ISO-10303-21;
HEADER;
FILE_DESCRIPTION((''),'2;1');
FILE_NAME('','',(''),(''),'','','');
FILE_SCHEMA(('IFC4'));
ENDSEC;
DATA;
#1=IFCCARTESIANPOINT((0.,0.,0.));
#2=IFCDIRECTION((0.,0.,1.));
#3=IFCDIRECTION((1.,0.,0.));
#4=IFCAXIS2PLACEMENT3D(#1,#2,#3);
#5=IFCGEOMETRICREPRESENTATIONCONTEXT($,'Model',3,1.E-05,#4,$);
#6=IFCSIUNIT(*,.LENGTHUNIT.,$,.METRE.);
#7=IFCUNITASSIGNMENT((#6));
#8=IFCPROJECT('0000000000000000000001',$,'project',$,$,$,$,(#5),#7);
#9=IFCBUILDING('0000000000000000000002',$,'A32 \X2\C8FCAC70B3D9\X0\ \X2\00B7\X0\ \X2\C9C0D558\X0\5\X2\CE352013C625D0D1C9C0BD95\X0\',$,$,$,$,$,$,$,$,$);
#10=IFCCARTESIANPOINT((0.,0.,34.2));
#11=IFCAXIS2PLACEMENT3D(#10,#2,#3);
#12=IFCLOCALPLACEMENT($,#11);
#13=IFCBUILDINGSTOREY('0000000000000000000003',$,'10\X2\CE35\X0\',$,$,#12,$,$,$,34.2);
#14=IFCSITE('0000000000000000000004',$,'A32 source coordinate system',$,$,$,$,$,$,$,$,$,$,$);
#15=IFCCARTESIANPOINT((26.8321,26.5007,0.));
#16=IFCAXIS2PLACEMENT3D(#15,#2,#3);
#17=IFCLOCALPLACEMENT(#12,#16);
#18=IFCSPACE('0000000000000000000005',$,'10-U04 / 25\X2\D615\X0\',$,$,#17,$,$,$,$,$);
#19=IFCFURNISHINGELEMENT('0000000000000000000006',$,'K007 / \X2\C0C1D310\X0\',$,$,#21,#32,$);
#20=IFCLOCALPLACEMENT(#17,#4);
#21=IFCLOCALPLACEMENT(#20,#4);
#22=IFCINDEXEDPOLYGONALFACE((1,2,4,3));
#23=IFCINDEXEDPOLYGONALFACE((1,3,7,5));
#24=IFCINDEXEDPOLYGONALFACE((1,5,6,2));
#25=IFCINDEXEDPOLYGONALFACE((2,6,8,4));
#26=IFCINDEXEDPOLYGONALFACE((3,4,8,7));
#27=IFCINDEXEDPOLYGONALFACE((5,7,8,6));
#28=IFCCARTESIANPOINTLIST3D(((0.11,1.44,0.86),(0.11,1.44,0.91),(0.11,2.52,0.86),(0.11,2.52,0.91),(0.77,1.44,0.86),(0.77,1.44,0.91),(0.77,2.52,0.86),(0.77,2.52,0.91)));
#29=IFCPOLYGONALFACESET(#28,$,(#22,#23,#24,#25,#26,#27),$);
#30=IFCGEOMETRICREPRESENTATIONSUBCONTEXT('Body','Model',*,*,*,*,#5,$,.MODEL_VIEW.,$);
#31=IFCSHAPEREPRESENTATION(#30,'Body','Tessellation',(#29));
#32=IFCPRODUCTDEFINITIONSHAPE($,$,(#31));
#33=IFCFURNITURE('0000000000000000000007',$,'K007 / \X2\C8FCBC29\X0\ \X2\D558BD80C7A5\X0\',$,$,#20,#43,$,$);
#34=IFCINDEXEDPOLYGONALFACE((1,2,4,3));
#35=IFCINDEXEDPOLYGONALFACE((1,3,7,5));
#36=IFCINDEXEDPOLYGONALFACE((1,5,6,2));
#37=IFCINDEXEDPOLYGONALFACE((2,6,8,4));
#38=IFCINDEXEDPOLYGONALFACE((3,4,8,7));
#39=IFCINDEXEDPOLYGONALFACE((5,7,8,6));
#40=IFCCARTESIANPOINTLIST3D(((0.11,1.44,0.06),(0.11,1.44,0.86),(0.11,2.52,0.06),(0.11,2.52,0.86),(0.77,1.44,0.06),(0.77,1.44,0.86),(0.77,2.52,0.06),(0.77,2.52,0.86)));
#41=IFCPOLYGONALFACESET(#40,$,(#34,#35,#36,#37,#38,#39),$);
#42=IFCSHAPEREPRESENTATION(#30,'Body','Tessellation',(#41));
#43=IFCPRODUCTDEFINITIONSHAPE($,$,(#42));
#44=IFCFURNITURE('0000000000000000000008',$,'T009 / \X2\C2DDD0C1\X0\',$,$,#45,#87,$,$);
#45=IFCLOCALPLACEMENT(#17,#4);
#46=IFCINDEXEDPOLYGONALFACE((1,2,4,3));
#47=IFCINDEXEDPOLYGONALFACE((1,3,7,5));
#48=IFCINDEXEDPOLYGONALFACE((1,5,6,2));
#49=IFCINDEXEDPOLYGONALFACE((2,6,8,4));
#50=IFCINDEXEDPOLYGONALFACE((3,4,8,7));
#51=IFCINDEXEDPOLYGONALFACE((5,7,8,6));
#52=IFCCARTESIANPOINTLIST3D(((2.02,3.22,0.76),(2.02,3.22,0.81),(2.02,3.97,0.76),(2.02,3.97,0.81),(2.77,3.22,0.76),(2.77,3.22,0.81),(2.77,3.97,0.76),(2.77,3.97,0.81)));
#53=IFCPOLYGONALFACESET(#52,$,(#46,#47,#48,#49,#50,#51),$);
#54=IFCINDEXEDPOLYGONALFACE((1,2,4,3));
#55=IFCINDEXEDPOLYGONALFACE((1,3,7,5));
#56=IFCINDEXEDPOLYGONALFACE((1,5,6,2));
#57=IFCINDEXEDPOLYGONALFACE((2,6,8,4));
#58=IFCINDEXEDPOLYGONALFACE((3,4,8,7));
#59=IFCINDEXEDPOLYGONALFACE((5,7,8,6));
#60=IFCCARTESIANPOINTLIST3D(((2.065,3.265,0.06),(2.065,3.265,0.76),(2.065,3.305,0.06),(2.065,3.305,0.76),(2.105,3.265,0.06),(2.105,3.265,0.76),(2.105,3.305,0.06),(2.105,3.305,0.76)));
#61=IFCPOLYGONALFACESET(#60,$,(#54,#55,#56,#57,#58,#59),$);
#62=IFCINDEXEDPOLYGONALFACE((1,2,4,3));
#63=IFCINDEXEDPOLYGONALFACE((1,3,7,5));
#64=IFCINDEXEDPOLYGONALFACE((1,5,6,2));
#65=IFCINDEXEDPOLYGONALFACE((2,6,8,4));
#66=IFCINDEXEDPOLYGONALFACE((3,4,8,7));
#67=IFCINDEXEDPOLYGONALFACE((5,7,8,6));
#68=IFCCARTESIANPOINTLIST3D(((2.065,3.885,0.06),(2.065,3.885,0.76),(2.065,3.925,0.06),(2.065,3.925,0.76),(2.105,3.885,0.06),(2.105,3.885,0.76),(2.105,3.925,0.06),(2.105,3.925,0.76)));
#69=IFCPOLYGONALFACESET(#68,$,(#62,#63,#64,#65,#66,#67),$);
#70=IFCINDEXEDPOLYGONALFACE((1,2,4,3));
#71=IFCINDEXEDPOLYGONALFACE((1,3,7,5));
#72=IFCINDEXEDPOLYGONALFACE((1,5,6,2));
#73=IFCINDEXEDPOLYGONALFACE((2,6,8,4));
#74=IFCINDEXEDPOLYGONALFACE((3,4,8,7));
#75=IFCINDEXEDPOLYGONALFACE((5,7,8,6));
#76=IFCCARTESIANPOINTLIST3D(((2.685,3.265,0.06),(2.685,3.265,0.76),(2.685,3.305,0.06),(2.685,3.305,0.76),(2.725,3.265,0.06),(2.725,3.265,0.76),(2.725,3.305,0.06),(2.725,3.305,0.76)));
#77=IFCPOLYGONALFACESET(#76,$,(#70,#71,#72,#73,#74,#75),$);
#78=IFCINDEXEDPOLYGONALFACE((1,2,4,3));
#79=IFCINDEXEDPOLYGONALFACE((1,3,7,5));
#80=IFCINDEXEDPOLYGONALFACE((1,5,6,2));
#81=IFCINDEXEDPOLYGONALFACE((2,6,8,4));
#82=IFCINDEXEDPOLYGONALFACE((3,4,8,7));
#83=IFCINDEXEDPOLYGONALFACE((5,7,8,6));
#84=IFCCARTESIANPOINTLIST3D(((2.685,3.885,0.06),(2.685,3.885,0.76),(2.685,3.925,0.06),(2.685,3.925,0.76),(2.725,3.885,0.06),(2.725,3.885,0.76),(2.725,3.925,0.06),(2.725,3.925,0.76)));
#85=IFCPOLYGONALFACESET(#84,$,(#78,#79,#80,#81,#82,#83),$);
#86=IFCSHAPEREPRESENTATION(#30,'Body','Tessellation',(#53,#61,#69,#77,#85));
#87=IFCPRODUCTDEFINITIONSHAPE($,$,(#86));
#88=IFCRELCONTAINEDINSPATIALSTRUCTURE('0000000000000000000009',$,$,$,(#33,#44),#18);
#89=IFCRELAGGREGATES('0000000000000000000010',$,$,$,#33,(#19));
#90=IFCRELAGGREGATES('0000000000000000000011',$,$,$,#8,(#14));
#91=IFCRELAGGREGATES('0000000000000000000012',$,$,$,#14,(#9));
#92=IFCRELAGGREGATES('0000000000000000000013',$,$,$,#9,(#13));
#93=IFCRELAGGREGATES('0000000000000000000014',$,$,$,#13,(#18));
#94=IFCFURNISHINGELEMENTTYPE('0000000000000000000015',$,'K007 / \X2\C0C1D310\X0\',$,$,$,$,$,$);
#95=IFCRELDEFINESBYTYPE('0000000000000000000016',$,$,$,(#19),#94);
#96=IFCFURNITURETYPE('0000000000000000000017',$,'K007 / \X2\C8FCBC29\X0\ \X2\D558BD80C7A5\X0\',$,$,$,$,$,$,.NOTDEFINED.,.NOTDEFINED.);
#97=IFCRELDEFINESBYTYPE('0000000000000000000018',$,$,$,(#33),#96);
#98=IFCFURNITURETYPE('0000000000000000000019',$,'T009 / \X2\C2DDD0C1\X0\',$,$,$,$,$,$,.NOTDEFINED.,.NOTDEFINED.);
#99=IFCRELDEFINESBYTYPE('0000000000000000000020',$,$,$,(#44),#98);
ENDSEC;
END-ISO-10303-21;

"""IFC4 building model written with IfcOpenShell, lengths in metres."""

from ifc_helpers import new_model, si_unit, frame, origin, origin_with_axes, place, context, subcontext, project, spatial, polyline, outline, extrude, source, transform, mapped, type_object, type_shapes, element, aggregate, save


model = new_model("IFC4")

# Units and contexts
model_context = context("Model", 3, precision=1e-05, world=origin_with_axes())
body_context = subcontext(model_context, "Body", "Model", "MODEL_VIEW")
ifc_project = project(units=[si_unit("LENGTHUNIT", "METRE")], contexts=[model_context])

# Site, building, storey
site = spatial("IfcSite", under=ifc_project, Name="A32 source coordinate system")
building = spatial("IfcBuilding", under=site, Name="A32 주거동 · 지하5층–옥탑지붕")
storey_placement = place(None, frame((0.0, 0.0, 34.2), z_axis=(0.0, 0.0, 1.0), x_axis=(1.0, 0.0, 0.0)))
storey = spatial("IfcBuildingStorey", under=building, at=storey_placement, Name="10층", Elevation=34.2)

# Shared definitions
space_1_placement = place(storey_placement, frame((26.8321, 26.5007, 0.0), z_axis=(0.0, 0.0, 1.0), x_axis=(1.0, 0.0, 0.0)))
space_1 = spatial("IfcSpace", under=storey, at=space_1_placement, Name="10-U04 / 25형")

# Furnishing element
furnishing_element_type_1 = type_object("IfcFurnishingElementType", Name="K007 / 상판")
shared_shape_1 = source(origin(), body_context, "Body", "SweptSolid", [
    extrude(outline(polyline([(0.77, 2.52), (0.77, 1.44), (0.11, 1.44), (0.11, 2.52), (0.77, 2.52)])), frame((0.0, 0.0, 0.86)), (0.0, 0.0, 1.0), 0.05),
])
type_shapes(furnishing_element_type_1, [shared_shape_1])
furniture_1_placement = place(space_1_placement, origin_with_axes())
furnishing_1_placement = place(furniture_1_placement, origin_with_axes())
furnishing_1 = element("IfcFurnishingElement", 1, at=furnishing_1_placement, type_object=furnishing_element_type_1, Name="K007 / 상판", context=body_context, shape_type="MappedRepresentation", body=[
    mapped(shared_shape_1, transform((0.0, 0.0, 0.0), scale=1.0)),
])

# Furniture
furniture_type_1 = type_object("IfcFurnitureType", Name="K007 / 주방 하부장", AssemblyPlace="NOTDEFINED", PredefinedType="NOTDEFINED")
shared_shape_2 = source(origin(), body_context, "Body", "SweptSolid", [
    extrude(outline(polyline([(0.11, 2.52), (0.77, 2.52), (0.77, 1.44), (0.11, 1.44), (0.11, 2.52)])), frame((0.0, 0.0, 0.06)), (0.0, 0.0, 1.0), 0.8),
])
type_shapes(furniture_type_1, [shared_shape_2])
furniture_1 = element("IfcFurniture", 2, at=furniture_1_placement, inside=space_1, type_object=furniture_type_1, Name="K007 / 주방 하부장", context=body_context, shape_type="MappedRepresentation", body=[
    mapped(shared_shape_2, transform((0.0, 0.0, 0.0), scale=1.0)),
])
aggregate(furniture_1, [furnishing_1])
furniture_type_2 = type_object("IfcFurnitureType", Name="T009 / 식탁", AssemblyPlace="NOTDEFINED", PredefinedType="NOTDEFINED")
shared_shape_3 = source(origin(), body_context, "Body", "SweptSolid", [
    extrude(outline(polyline([(2.77, 3.22), (2.02, 3.22), (2.02, 3.97), (2.77, 3.97), (2.77, 3.22)])), frame((0.0, 0.0, 0.76)), (0.0, 0.0, 1.0), 0.05),
    extrude(outline(polyline([(2.065, 3.265), (2.065, 3.305), (2.105, 3.305), (2.105, 3.265), (2.065, 3.265)])), frame((0.0, 0.0, 0.06)), (0.0, 0.0, 1.0), 0.7),
    extrude(outline(polyline([(2.065, 3.885), (2.065, 3.925), (2.105, 3.925), (2.105, 3.885), (2.065, 3.885)])), frame((0.0, 0.0, 0.06)), (0.0, 0.0, 1.0), 0.7),
    extrude(outline(polyline([(2.685, 3.265), (2.685, 3.305), (2.725, 3.305), (2.725, 3.265), (2.685, 3.265)])), frame((0.0, 0.0, 0.06)), (0.0, 0.0, 1.0), 0.7),
    extrude(outline(polyline([(2.685, 3.885), (2.685, 3.925), (2.725, 3.925), (2.725, 3.885), (2.685, 3.885)])), frame((0.0, 0.0, 0.06)), (0.0, 0.0, 1.0), 0.7),
])
type_shapes(furniture_type_2, [shared_shape_3])
furniture_2_placement = place(space_1_placement, origin_with_axes())
element("IfcFurniture", 3, at=furniture_2_placement, inside=space_1, type_object=furniture_type_2, Name="T009 / 식탁", context=body_context, shape_type="MappedRepresentation", body=[
    mapped(shared_shape_3, transform((0.0, 0.0, 0.0), scale=1.0)),
])

save(model, "model.ifc")
